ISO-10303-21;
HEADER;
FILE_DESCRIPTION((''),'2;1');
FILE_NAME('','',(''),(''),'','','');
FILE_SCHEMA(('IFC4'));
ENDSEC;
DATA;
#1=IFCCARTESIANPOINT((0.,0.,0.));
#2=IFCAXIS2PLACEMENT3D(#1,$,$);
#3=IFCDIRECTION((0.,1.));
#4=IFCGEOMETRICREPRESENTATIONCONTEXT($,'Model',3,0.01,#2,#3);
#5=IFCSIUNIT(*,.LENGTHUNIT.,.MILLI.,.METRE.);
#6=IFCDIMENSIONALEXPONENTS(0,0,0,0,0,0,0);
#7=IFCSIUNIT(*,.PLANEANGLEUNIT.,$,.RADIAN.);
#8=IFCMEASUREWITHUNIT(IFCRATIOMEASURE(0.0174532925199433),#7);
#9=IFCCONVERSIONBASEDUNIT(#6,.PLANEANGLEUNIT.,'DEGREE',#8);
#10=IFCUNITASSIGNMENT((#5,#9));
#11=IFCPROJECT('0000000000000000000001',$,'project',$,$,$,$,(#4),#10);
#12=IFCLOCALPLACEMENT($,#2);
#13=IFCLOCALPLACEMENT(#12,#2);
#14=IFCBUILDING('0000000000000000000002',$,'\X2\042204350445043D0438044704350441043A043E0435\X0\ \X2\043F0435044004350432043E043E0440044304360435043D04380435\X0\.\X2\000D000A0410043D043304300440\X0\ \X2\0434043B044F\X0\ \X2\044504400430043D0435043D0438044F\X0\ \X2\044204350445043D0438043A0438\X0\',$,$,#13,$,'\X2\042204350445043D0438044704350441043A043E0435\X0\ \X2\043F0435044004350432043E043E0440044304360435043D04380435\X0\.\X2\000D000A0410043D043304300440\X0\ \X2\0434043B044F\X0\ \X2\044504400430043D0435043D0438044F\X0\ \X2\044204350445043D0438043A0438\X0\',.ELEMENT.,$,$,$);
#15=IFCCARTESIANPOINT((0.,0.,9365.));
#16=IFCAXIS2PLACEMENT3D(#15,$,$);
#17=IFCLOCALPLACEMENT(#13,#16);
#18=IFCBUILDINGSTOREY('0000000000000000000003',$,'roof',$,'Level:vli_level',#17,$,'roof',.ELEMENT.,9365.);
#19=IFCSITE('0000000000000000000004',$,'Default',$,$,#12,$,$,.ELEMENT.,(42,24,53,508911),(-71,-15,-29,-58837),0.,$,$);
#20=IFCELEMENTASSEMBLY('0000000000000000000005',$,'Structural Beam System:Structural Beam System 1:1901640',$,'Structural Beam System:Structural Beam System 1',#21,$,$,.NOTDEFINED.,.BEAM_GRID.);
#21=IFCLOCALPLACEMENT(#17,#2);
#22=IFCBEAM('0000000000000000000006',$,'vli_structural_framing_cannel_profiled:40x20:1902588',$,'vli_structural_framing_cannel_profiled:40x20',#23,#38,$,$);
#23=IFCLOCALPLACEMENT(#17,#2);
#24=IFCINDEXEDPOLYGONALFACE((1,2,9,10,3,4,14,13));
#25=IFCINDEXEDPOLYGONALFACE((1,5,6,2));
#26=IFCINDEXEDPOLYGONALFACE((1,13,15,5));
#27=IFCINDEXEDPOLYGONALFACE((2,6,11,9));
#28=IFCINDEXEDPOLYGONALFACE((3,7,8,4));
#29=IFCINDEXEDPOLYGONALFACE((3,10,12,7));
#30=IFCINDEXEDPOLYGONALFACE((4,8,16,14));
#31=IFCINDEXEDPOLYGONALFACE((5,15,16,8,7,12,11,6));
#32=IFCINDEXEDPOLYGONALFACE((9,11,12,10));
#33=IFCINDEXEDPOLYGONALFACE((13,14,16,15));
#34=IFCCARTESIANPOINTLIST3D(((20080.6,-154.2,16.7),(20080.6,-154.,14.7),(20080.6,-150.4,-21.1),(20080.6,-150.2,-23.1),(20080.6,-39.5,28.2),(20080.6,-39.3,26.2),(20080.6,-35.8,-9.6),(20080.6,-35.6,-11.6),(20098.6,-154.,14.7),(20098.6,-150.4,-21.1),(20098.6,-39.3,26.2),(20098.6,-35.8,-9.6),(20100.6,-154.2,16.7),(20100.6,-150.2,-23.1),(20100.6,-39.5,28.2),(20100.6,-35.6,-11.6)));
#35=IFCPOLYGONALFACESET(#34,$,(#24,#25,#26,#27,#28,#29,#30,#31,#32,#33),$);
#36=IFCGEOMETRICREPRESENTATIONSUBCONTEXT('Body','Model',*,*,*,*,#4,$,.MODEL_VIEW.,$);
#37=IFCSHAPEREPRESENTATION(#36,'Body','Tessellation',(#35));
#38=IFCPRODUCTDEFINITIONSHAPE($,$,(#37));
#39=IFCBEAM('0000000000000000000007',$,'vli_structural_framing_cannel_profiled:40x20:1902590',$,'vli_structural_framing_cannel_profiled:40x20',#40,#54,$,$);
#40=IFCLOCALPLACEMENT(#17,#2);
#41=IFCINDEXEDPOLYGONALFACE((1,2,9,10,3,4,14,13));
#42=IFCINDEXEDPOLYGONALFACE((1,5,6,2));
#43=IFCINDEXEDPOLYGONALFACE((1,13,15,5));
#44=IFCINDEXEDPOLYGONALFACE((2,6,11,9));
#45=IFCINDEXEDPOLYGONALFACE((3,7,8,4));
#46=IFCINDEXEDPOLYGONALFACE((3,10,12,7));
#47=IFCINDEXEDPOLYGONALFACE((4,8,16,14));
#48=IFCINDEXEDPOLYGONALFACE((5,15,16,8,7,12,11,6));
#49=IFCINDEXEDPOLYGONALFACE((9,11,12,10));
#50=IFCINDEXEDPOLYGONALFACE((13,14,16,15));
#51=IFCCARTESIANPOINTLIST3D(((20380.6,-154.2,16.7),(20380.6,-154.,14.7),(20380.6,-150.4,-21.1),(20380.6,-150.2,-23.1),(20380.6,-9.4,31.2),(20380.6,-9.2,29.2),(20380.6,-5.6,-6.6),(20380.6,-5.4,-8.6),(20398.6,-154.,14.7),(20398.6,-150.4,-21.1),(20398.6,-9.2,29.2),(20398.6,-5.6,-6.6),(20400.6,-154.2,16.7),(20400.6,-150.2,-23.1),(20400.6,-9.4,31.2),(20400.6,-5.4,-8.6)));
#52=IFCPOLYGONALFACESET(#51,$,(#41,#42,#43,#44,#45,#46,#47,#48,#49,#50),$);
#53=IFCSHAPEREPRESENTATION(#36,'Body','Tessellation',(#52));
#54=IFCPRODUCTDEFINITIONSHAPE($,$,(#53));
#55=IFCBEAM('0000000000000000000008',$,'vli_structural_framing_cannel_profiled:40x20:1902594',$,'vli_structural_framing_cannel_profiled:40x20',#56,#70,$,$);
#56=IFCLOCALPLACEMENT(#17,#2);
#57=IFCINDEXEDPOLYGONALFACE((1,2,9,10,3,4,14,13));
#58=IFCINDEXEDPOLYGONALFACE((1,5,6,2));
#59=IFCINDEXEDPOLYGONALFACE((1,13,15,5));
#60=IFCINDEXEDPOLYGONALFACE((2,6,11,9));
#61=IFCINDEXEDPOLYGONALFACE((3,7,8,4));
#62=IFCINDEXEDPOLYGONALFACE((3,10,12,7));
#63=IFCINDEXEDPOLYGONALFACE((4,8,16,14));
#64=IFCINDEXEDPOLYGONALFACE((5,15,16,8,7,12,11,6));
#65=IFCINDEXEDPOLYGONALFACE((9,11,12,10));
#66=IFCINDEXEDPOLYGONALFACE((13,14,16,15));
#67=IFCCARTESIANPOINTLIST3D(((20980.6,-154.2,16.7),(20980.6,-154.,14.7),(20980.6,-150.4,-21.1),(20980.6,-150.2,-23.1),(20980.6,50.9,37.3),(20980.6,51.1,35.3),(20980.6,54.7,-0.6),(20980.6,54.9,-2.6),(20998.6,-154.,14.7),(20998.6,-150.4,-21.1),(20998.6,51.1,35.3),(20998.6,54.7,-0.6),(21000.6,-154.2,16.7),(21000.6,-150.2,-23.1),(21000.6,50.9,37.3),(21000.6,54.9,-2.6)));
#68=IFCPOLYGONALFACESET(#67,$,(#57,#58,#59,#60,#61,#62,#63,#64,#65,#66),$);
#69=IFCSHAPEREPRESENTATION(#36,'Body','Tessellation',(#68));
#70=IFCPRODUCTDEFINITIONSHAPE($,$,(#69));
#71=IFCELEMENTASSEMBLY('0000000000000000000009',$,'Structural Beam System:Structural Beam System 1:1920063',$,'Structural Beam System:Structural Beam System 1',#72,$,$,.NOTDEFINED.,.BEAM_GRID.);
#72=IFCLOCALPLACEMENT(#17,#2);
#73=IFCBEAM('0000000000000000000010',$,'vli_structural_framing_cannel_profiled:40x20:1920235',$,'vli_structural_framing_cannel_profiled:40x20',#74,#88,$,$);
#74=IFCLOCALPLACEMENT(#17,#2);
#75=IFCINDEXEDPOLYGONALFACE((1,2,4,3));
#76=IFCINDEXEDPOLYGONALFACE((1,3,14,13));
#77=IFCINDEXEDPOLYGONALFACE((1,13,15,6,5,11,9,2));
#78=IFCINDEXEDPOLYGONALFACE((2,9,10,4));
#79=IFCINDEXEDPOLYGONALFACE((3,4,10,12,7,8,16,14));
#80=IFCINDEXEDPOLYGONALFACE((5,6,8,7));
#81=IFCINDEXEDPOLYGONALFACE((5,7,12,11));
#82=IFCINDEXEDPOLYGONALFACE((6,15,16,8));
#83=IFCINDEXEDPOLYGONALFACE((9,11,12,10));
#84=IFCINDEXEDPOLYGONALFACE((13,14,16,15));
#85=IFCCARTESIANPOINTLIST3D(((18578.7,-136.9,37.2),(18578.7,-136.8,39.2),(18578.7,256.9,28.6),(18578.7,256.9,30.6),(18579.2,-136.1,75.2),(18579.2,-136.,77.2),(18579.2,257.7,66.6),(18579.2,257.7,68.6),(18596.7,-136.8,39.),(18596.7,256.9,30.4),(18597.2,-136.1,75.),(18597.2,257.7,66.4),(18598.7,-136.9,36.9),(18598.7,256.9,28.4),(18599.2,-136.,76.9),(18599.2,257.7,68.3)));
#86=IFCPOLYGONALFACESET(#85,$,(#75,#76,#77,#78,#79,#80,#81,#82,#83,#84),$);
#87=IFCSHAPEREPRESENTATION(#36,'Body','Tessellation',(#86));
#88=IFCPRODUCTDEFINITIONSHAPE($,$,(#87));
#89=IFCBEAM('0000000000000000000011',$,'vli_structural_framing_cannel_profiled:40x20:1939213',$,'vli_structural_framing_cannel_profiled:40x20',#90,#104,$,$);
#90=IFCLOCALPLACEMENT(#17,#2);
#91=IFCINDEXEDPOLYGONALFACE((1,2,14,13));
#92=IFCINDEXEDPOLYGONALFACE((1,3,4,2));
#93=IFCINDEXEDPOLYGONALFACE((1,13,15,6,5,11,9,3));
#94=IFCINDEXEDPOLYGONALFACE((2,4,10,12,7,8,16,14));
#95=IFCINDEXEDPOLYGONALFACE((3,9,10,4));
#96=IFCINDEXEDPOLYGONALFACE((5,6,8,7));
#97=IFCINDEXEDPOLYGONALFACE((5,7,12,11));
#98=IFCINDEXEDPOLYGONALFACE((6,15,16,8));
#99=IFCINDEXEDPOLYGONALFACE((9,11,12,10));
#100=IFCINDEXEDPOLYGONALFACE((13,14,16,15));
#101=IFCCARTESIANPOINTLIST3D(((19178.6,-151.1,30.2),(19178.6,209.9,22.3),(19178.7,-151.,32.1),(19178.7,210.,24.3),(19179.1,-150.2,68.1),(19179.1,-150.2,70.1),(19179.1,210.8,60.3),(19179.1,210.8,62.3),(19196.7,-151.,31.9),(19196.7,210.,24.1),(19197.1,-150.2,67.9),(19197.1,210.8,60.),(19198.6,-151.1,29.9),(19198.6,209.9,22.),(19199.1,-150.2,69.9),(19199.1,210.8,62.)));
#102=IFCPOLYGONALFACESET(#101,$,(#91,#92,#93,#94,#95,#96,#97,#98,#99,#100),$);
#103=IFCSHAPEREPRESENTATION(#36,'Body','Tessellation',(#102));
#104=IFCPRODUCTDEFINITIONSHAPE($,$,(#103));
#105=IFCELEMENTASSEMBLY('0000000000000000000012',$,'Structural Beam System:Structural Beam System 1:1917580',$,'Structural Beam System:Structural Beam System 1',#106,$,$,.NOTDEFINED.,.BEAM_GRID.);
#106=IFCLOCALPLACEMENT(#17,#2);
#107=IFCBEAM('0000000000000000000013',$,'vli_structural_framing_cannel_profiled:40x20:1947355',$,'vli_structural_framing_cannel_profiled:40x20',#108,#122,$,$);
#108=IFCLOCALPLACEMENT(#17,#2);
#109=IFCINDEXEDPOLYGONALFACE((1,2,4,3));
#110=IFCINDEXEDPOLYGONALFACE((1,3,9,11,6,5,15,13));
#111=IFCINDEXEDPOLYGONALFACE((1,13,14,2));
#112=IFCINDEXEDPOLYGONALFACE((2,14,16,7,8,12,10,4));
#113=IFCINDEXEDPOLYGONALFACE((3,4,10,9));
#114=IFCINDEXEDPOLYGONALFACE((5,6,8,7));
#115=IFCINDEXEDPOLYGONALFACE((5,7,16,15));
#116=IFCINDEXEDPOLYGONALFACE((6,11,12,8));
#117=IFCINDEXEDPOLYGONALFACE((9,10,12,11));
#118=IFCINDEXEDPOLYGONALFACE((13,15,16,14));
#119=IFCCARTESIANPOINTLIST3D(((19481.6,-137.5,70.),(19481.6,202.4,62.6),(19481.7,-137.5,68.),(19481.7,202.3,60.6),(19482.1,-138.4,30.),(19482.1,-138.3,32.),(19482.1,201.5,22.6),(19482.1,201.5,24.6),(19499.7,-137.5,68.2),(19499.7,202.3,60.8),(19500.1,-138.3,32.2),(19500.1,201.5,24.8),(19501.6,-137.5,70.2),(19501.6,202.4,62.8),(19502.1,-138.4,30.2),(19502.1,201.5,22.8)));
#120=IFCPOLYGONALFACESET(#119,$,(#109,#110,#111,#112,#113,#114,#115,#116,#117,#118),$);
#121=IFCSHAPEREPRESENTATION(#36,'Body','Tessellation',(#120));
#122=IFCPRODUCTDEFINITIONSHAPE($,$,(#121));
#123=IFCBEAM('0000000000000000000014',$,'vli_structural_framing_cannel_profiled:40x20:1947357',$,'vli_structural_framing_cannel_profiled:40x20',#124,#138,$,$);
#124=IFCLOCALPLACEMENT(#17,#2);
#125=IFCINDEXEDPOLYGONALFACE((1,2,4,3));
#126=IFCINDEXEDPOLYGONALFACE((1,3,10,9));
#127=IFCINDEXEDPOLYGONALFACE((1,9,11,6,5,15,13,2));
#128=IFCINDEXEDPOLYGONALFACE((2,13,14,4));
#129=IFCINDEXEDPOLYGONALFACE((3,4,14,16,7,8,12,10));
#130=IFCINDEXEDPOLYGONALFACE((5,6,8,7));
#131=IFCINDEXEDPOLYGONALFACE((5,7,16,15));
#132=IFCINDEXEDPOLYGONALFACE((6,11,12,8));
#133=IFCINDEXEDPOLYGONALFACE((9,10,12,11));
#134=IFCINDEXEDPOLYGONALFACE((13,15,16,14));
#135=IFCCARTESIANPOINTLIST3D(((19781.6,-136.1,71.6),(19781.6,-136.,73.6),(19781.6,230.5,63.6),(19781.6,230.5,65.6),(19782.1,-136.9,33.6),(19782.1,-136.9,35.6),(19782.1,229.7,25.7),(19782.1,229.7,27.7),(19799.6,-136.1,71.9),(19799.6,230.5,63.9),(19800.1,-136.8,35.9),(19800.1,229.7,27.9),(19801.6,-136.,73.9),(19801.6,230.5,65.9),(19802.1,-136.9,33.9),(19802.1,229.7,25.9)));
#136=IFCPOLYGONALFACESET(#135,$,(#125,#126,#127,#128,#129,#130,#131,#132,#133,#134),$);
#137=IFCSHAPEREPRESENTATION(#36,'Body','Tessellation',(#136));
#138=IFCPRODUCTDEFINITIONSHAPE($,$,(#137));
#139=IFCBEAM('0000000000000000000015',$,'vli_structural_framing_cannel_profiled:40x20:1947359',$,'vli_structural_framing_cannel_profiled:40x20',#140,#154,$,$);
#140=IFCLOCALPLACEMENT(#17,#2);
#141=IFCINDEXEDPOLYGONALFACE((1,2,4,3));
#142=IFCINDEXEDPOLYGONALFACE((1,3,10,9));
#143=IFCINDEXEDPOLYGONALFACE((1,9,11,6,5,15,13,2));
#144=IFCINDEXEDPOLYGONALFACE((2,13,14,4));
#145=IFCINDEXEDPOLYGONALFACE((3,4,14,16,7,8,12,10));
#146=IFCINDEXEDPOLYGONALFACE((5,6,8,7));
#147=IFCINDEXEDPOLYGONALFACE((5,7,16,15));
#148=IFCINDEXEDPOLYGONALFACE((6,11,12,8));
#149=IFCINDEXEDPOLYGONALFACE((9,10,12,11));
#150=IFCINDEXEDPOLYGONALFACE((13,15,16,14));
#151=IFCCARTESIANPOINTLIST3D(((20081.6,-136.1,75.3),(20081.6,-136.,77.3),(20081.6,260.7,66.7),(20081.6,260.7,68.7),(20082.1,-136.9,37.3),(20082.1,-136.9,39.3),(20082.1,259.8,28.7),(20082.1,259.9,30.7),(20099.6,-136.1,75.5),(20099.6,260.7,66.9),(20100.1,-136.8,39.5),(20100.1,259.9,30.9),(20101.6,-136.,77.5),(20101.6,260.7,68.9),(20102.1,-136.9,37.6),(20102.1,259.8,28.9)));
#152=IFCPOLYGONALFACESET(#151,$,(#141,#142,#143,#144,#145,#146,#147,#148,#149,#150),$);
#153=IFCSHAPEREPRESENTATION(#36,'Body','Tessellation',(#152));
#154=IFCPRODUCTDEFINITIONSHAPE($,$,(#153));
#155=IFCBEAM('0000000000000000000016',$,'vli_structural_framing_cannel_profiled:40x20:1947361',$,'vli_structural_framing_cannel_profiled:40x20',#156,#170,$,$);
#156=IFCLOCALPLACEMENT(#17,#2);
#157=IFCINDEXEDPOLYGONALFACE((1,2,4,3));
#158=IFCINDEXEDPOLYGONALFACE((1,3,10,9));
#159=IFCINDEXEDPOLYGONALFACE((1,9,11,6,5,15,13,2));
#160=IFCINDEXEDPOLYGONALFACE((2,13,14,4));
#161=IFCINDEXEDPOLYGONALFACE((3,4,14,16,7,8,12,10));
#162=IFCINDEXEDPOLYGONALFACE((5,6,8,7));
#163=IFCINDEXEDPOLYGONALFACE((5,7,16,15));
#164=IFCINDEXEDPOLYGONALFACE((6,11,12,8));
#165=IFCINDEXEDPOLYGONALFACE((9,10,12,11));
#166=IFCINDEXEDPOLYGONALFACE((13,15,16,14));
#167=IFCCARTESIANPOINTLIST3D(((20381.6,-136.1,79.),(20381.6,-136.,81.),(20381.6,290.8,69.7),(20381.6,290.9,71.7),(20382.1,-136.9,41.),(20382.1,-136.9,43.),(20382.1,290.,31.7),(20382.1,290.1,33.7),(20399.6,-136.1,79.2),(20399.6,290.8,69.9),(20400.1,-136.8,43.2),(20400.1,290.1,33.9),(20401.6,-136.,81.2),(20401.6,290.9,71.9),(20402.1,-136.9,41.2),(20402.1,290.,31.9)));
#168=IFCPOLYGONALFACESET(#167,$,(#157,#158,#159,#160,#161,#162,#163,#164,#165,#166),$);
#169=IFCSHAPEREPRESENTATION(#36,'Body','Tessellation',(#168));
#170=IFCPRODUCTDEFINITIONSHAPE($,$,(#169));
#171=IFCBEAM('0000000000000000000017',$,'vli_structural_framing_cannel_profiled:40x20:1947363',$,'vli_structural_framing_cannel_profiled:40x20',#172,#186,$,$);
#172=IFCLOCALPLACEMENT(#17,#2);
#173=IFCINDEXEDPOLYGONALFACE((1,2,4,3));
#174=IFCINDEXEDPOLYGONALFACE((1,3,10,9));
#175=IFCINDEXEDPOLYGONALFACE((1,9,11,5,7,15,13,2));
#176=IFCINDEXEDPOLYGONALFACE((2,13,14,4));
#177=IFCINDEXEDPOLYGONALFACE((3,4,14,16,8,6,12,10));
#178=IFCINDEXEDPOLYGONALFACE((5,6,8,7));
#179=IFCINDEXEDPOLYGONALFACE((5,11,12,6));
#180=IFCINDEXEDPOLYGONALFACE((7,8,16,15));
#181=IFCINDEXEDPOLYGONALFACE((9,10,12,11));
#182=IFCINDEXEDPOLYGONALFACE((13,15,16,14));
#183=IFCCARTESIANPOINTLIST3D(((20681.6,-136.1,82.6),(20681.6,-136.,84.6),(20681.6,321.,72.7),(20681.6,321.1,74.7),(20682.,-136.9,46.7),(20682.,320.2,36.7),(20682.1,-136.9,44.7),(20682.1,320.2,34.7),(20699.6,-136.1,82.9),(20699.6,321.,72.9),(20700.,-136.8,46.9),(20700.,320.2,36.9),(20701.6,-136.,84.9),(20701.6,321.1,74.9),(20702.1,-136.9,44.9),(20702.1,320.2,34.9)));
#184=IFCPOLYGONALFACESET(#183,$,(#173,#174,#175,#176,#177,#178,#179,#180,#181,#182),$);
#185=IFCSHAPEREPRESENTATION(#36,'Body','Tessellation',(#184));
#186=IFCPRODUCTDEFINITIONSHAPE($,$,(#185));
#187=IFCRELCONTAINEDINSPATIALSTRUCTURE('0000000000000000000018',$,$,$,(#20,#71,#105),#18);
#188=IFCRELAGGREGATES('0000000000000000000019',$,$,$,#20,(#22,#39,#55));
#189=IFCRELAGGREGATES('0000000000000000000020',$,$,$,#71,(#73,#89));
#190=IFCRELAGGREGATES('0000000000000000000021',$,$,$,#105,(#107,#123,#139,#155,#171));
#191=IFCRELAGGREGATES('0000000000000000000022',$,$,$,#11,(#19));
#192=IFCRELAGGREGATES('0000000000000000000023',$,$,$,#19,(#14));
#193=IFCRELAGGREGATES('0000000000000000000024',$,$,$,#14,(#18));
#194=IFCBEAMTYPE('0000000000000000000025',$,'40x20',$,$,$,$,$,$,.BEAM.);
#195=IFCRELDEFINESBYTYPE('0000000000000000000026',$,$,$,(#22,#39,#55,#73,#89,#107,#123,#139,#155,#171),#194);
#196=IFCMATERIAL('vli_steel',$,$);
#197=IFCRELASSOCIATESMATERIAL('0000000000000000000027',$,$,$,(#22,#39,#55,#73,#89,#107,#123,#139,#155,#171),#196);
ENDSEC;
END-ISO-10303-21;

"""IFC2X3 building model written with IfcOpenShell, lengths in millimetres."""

from ifc_helpers import new_model, entity, si_unit, converted_unit, direction, frame, origin, place, context, subcontext, project, spatial, polyline, outline, extrude, material, type_object, element, aggregate, save


model = new_model("IFC2X3")

# Units and contexts
model_context = context("Model", 3, precision=0.01, world=origin(), true_north=direction((0.0, 1.0)))
body_context = subcontext(model_context, "Body", "Model", "MODEL_VIEW")
ifc_project = project(units=[si_unit("LENGTHUNIT", "METRE", prefix="MILLI"), converted_unit("PLANEANGLEUNIT", "DEGREE", entity("IfcRatioMeasure", 0.0174532925199433), si_unit("PLANEANGLEUNIT", "RADIAN"), dimensions=[0, 0, 0, 0, 0, 0, 0])], contexts=[model_context])

# Site, building, storey
site_placement = place(None, origin())
site = spatial("IfcSite", under=ifc_project, at=site_placement, Name="Default", CompositionType="ELEMENT", RefLatitude=(42, 24, 53, 508911), RefLongitude=(-71, -15, -29, -58837), RefElevation=0.0)
building_placement = place(site_placement, origin())
building = spatial("IfcBuilding", under=site, at=building_placement, Name="Техническое перевооружение.\r\nАнгар для хранения техники", LongName="Техническое перевооружение.\r\nАнгар для хранения техники", CompositionType="ELEMENT")
storey_placement = place(building_placement, frame((0.0, 0.0, 9365.0)))
storey = spatial("IfcBuildingStorey", under=building, at=storey_placement, Name="roof", ObjectType="Level:vli_level", LongName="roof", CompositionType="ELEMENT", Elevation=9365.0)

# Element assemblies, beams
assembly_1_placement = place(storey_placement, origin())
assembly_1 = element("IfcElementAssembly", 1, at=assembly_1_placement, inside=storey, Name="Structural Beam System:Structural Beam System 1:1901640", ObjectType="Structural Beam System:Structural Beam System 1", AssemblyPlace="NOTDEFINED", PredefinedType="BEAM_GRID")
ifc_material = material(Name="vli_steel")
beam_type = type_object("IfcBeamType", Name="40x20", PredefinedType="BEAM")
beam_1_placement = place(assembly_1_placement, frame((20100.0, -20.4, -10.1), z_axis=(0.0, -0.099504, 0.995037), x_axis=(0.0, -0.995037, -0.099504)))
beam_1 = element("IfcBeam", 2, at=beam_1_placement, type_object=beam_type, material=ifc_material, Name="vli_structural_framing_cannel_profiled:40x20:1902588", ObjectType="vli_structural_framing_cannel_profiled:40x20", context=body_context, shape_type="SweptSolid", body=[
    extrude(outline(polyline([(-20.0, -9.5), (-18.0, -9.5), (-18.0, 8.5), (18.0, 8.5), (18.0, -9.5), (20.0, -9.5), (20.0, 10.5), (-20.0, 10.5), (-20.0, -9.5)])), frame((15.3, -9.9, 20.0), z_axis=(1.0, 0.0, 0.0), x_axis=(0.0, 0.0, -1.0)), (0.0, 0.0, 1.0), 115.3),
])
beam_2_placement = place(assembly_1_placement, frame((20400.0, 9.8, -7.1), z_axis=(0.0, -0.099504, 0.995037), x_axis=(0.0, -0.995037, -0.099504)))
beam_2 = element("IfcBeam", 3, at=beam_2_placement, type_object=beam_type, material=ifc_material, Name="vli_structural_framing_cannel_profiled:40x20:1902590", ObjectType="vli_structural_framing_cannel_profiled:40x20", context=body_context, shape_type="SweptSolid", body=[
    extrude(outline(polyline([(-20.0, -9.5), (-18.0, -9.5), (-18.0, 8.5), (18.0, 8.5), (18.0, -9.5), (20.0, -9.5), (20.0, 10.5), (-20.0, 10.5), (-20.0, -9.5)])), frame((15.3, -9.9, 20.0), z_axis=(1.0, 0.0, 0.0), x_axis=(0.0, 0.0, -1.0)), (0.0, 0.0, 1.0), 145.6),
])
beam_3_placement = place(assembly_1_placement, frame((21000.0, 70.1, -1.0), z_axis=(0.0, -0.099504, 0.995037), x_axis=(0.0, -0.995037, -0.099504)))
beam_3 = element("IfcBeam", 4, at=beam_3_placement, type_object=beam_type, material=ifc_material, Name="vli_structural_framing_cannel_profiled:40x20:1902594", ObjectType="vli_structural_framing_cannel_profiled:40x20", context=body_context, shape_type="SweptSolid", body=[
    extrude(outline(polyline([(-20.0, -9.5), (-18.0, -9.5), (-18.0, 8.5), (18.0, 8.5), (18.0, -9.5), (20.0, -9.5), (20.0, 10.5), (-20.0, 10.5), (-20.0, -9.5)])), frame((15.3, -9.9, 20.0), z_axis=(1.0, 0.0, 0.0), x_axis=(0.0, 0.0, -1.0)), (0.0, 0.0, 1.0), 206.2),
])
aggregate(assembly_1, [beam_1, beam_2, beam_3])
assembly_2_placement = place(storey_placement, origin())
assembly_2 = element("IfcElementAssembly", 5, at=assembly_2_placement, inside=storey, Name="Structural Beam System:Structural Beam System 1:1920063", ObjectType="Structural Beam System:Structural Beam System 1", AssemblyPlace="NOTDEFINED", PredefinedType="BEAM_GRID")
beam_4_placement = place(assembly_2_placement, frame((18598.6, 271.1, 68.1), z_axis=(0.0, 0.021793, 0.999763), x_axis=(0.0, -0.999763, 0.021793)))
beam_4 = element("IfcBeam", 6, at=beam_4_placement, type_object=beam_type, material=ifc_material, Name="vli_structural_framing_cannel_profiled:40x20:1920235", ObjectType="vli_structural_framing_cannel_profiled:40x20", context=body_context, shape_type="SweptSolid", body=[
    extrude(outline(polyline([(-10.5, -20.0), (9.5, -20.0), (9.5, -18.0), (-8.5, -18.0), (-8.5, 18.0), (9.5, 18.0), (9.5, 20.0), (-10.5, 20.0), (-10.5, -20.0)])), frame((13.4, -10.1, -19.9), z_axis=(1.0, 0.0, 0.0), x_axis=(0.0, -0.999925, 0.012237)), (0.0, 0.0, 1.0), 393.9),
])

# Beam
beam_5_placement = place(assembly_2_placement, frame((19198.5, 210.8, 62.0), z_axis=(0.0, 0.021793, 0.999763), x_axis=(0.0, -0.999763, 0.021793)))
beam_5 = element("IfcBeam", 7, at=beam_5_placement, type_object=beam_type, material=ifc_material, Name="vli_structural_framing_cannel_profiled:40x20:1939213", ObjectType="vli_structural_framing_cannel_profiled:40x20", context=body_context, shape_type="SweptSolid", body=[
    extrude(outline(polyline([(-10.5, -20.0), (9.5, -20.0), (9.5, -18.0), (-8.5, -18.0), (-8.5, 18.0), (9.5, 18.0), (9.5, 20.0), (-10.5, 20.0), (-10.5, -20.0)])), frame((0.0, -10.1, -19.9), z_axis=(1.0, 0.0, 0.0), x_axis=(0.0, -0.999925, 0.012237)), (0.0, 0.0, 1.0), 361.1),
])
aggregate(assembly_2, [beam_4, beam_5])

# Element assembly, beams
assembly_3_placement = place(storey_placement, origin())
assembly_3 = element("IfcElementAssembly", 8, at=assembly_3_placement, inside=storey, Name="Structural Beam System:Structural Beam System 1:1917580", ObjectType="Structural Beam System:Structural Beam System 1", AssemblyPlace="NOTDEFINED", PredefinedType="BEAM_GRID")
beam_6_placement = place(assembly_3_placement, frame((19501.0, 215.6, 62.5), z_axis=(0.0, 0.02179, 0.999763), x_axis=(0.0, -0.999763, 0.02179)))
beam_6 = element("IfcBeam", 9, at=beam_6_placement, type_object=beam_type, material=ifc_material, Name="vli_structural_framing_cannel_profiled:40x20:1947355", ObjectType="vli_structural_framing_cannel_profiled:40x20", context=body_context, shape_type="SweptSolid", body=[
    extrude(outline(polyline([(-10.5, -20.0), (9.5, -20.0), (9.5, -18.0), (-8.5, -18.0), (-8.5, 18.0), (9.5, 18.0), (9.5, 20.0), (-10.5, 20.0), (-10.5, -20.0)])), frame((13.2, -9.7, -20.1), z_axis=(1.0, 0.0, 0.0), x_axis=(0.0, -0.999925, -0.012243)), (0.0, 0.0, 1.0), 339.9),
])
beam_7_placement = place(assembly_3_placement, frame((19801.0, 245.8, 65.5), z_axis=(0.0, 0.02179, 0.999763), x_axis=(0.0, -0.999763, 0.02179)))
beam_7 = element("IfcBeam", 10, at=beam_7_placement, type_object=beam_type, material=ifc_material, Name="vli_structural_framing_cannel_profiled:40x20:1947357", ObjectType="vli_structural_framing_cannel_profiled:40x20", context=body_context, shape_type="SweptSolid", body=[
    extrude(outline(polyline([(-10.5, -20.0), (9.5, -20.0), (9.5, -18.0), (-8.5, -18.0), (-8.5, 18.0), (9.5, 18.0), (9.5, 20.0), (-10.5, 20.0), (-10.5, -20.0)])), frame((15.3, -9.7, -20.1), z_axis=(1.0, 0.0, 0.0), x_axis=(0.0, -0.999925, -0.012243)), (0.0, 0.0, 1.0), 366.6),
])
beam_8_placement = place(assembly_3_placement, frame((20101.0, 276.0, 68.6), z_axis=(0.0, 0.02179, 0.999763), x_axis=(0.0, -0.999763, 0.02179)))
beam_8 = element("IfcBeam", 11, at=beam_8_placement, type_object=beam_type, material=ifc_material, Name="vli_structural_framing_cannel_profiled:40x20:1947359", ObjectType="vli_structural_framing_cannel_profiled:40x20", context=body_context, shape_type="SweptSolid", body=[
    extrude(outline(polyline([(-10.5, -20.0), (9.5, -20.0), (9.5, -18.0), (-8.5, -18.0), (-8.5, 18.0), (9.5, 18.0), (9.5, 20.0), (-10.5, 20.0), (-10.5, -20.0)])), frame((15.3, -9.7, -20.1), z_axis=(1.0, 0.0, 0.0), x_axis=(0.0, -0.999925, -0.012243)), (0.0, 0.0, 1.0), 396.8),
])
beam_9_placement = place(assembly_3_placement, frame((20401.0, 306.1, 71.6), z_axis=(0.0, 0.02179, 0.999763), x_axis=(0.0, -0.999763, 0.02179)))
beam_9 = element("IfcBeam", 12, at=beam_9_placement, type_object=beam_type, material=ifc_material, Name="vli_structural_framing_cannel_profiled:40x20:1947361", ObjectType="vli_structural_framing_cannel_profiled:40x20", context=body_context, shape_type="SweptSolid", body=[
    extrude(outline(polyline([(-10.5, -20.0), (9.5, -20.0), (9.5, -18.0), (-8.5, -18.0), (-8.5, 18.0), (9.5, 18.0), (9.5, 20.0), (-10.5, 20.0), (-10.5, -20.0)])), frame((15.3, -9.7, -20.1), z_axis=(1.0, 0.0, 0.0), x_axis=(0.0, -0.999925, -0.012243)), (0.0, 0.0, 1.0), 427.0),
])
beam_10_placement = place(assembly_3_placement, frame((20701.0, 336.3, 74.6), z_axis=(0.0, 0.02179, 0.999763), x_axis=(0.0, -0.999763, 0.02179)))
beam_10 = element("IfcBeam", 13, at=beam_10_placement, type_object=beam_type, material=ifc_material, Name="vli_structural_framing_cannel_profiled:40x20:1947363", ObjectType="vli_structural_framing_cannel_profiled:40x20", context=body_context, shape_type="SweptSolid", body=[
    extrude(outline(polyline([(-10.5, -20.0), (9.5, -20.0), (9.5, -18.0), (-8.5, -18.0), (-8.5, 18.0), (9.5, 18.0), (9.5, 20.0), (-10.5, 20.0), (-10.5, -20.0)])), frame((15.3, -9.7, -20.1), z_axis=(1.0, 0.0, 0.0), x_axis=(0.0, -0.999925, -0.012243)), (0.0, 0.0, 1.0), 457.2),
])
aggregate(assembly_3, [beam_6, beam_7, beam_8, beam_9, beam_10])

save(model, "model.ifc")
